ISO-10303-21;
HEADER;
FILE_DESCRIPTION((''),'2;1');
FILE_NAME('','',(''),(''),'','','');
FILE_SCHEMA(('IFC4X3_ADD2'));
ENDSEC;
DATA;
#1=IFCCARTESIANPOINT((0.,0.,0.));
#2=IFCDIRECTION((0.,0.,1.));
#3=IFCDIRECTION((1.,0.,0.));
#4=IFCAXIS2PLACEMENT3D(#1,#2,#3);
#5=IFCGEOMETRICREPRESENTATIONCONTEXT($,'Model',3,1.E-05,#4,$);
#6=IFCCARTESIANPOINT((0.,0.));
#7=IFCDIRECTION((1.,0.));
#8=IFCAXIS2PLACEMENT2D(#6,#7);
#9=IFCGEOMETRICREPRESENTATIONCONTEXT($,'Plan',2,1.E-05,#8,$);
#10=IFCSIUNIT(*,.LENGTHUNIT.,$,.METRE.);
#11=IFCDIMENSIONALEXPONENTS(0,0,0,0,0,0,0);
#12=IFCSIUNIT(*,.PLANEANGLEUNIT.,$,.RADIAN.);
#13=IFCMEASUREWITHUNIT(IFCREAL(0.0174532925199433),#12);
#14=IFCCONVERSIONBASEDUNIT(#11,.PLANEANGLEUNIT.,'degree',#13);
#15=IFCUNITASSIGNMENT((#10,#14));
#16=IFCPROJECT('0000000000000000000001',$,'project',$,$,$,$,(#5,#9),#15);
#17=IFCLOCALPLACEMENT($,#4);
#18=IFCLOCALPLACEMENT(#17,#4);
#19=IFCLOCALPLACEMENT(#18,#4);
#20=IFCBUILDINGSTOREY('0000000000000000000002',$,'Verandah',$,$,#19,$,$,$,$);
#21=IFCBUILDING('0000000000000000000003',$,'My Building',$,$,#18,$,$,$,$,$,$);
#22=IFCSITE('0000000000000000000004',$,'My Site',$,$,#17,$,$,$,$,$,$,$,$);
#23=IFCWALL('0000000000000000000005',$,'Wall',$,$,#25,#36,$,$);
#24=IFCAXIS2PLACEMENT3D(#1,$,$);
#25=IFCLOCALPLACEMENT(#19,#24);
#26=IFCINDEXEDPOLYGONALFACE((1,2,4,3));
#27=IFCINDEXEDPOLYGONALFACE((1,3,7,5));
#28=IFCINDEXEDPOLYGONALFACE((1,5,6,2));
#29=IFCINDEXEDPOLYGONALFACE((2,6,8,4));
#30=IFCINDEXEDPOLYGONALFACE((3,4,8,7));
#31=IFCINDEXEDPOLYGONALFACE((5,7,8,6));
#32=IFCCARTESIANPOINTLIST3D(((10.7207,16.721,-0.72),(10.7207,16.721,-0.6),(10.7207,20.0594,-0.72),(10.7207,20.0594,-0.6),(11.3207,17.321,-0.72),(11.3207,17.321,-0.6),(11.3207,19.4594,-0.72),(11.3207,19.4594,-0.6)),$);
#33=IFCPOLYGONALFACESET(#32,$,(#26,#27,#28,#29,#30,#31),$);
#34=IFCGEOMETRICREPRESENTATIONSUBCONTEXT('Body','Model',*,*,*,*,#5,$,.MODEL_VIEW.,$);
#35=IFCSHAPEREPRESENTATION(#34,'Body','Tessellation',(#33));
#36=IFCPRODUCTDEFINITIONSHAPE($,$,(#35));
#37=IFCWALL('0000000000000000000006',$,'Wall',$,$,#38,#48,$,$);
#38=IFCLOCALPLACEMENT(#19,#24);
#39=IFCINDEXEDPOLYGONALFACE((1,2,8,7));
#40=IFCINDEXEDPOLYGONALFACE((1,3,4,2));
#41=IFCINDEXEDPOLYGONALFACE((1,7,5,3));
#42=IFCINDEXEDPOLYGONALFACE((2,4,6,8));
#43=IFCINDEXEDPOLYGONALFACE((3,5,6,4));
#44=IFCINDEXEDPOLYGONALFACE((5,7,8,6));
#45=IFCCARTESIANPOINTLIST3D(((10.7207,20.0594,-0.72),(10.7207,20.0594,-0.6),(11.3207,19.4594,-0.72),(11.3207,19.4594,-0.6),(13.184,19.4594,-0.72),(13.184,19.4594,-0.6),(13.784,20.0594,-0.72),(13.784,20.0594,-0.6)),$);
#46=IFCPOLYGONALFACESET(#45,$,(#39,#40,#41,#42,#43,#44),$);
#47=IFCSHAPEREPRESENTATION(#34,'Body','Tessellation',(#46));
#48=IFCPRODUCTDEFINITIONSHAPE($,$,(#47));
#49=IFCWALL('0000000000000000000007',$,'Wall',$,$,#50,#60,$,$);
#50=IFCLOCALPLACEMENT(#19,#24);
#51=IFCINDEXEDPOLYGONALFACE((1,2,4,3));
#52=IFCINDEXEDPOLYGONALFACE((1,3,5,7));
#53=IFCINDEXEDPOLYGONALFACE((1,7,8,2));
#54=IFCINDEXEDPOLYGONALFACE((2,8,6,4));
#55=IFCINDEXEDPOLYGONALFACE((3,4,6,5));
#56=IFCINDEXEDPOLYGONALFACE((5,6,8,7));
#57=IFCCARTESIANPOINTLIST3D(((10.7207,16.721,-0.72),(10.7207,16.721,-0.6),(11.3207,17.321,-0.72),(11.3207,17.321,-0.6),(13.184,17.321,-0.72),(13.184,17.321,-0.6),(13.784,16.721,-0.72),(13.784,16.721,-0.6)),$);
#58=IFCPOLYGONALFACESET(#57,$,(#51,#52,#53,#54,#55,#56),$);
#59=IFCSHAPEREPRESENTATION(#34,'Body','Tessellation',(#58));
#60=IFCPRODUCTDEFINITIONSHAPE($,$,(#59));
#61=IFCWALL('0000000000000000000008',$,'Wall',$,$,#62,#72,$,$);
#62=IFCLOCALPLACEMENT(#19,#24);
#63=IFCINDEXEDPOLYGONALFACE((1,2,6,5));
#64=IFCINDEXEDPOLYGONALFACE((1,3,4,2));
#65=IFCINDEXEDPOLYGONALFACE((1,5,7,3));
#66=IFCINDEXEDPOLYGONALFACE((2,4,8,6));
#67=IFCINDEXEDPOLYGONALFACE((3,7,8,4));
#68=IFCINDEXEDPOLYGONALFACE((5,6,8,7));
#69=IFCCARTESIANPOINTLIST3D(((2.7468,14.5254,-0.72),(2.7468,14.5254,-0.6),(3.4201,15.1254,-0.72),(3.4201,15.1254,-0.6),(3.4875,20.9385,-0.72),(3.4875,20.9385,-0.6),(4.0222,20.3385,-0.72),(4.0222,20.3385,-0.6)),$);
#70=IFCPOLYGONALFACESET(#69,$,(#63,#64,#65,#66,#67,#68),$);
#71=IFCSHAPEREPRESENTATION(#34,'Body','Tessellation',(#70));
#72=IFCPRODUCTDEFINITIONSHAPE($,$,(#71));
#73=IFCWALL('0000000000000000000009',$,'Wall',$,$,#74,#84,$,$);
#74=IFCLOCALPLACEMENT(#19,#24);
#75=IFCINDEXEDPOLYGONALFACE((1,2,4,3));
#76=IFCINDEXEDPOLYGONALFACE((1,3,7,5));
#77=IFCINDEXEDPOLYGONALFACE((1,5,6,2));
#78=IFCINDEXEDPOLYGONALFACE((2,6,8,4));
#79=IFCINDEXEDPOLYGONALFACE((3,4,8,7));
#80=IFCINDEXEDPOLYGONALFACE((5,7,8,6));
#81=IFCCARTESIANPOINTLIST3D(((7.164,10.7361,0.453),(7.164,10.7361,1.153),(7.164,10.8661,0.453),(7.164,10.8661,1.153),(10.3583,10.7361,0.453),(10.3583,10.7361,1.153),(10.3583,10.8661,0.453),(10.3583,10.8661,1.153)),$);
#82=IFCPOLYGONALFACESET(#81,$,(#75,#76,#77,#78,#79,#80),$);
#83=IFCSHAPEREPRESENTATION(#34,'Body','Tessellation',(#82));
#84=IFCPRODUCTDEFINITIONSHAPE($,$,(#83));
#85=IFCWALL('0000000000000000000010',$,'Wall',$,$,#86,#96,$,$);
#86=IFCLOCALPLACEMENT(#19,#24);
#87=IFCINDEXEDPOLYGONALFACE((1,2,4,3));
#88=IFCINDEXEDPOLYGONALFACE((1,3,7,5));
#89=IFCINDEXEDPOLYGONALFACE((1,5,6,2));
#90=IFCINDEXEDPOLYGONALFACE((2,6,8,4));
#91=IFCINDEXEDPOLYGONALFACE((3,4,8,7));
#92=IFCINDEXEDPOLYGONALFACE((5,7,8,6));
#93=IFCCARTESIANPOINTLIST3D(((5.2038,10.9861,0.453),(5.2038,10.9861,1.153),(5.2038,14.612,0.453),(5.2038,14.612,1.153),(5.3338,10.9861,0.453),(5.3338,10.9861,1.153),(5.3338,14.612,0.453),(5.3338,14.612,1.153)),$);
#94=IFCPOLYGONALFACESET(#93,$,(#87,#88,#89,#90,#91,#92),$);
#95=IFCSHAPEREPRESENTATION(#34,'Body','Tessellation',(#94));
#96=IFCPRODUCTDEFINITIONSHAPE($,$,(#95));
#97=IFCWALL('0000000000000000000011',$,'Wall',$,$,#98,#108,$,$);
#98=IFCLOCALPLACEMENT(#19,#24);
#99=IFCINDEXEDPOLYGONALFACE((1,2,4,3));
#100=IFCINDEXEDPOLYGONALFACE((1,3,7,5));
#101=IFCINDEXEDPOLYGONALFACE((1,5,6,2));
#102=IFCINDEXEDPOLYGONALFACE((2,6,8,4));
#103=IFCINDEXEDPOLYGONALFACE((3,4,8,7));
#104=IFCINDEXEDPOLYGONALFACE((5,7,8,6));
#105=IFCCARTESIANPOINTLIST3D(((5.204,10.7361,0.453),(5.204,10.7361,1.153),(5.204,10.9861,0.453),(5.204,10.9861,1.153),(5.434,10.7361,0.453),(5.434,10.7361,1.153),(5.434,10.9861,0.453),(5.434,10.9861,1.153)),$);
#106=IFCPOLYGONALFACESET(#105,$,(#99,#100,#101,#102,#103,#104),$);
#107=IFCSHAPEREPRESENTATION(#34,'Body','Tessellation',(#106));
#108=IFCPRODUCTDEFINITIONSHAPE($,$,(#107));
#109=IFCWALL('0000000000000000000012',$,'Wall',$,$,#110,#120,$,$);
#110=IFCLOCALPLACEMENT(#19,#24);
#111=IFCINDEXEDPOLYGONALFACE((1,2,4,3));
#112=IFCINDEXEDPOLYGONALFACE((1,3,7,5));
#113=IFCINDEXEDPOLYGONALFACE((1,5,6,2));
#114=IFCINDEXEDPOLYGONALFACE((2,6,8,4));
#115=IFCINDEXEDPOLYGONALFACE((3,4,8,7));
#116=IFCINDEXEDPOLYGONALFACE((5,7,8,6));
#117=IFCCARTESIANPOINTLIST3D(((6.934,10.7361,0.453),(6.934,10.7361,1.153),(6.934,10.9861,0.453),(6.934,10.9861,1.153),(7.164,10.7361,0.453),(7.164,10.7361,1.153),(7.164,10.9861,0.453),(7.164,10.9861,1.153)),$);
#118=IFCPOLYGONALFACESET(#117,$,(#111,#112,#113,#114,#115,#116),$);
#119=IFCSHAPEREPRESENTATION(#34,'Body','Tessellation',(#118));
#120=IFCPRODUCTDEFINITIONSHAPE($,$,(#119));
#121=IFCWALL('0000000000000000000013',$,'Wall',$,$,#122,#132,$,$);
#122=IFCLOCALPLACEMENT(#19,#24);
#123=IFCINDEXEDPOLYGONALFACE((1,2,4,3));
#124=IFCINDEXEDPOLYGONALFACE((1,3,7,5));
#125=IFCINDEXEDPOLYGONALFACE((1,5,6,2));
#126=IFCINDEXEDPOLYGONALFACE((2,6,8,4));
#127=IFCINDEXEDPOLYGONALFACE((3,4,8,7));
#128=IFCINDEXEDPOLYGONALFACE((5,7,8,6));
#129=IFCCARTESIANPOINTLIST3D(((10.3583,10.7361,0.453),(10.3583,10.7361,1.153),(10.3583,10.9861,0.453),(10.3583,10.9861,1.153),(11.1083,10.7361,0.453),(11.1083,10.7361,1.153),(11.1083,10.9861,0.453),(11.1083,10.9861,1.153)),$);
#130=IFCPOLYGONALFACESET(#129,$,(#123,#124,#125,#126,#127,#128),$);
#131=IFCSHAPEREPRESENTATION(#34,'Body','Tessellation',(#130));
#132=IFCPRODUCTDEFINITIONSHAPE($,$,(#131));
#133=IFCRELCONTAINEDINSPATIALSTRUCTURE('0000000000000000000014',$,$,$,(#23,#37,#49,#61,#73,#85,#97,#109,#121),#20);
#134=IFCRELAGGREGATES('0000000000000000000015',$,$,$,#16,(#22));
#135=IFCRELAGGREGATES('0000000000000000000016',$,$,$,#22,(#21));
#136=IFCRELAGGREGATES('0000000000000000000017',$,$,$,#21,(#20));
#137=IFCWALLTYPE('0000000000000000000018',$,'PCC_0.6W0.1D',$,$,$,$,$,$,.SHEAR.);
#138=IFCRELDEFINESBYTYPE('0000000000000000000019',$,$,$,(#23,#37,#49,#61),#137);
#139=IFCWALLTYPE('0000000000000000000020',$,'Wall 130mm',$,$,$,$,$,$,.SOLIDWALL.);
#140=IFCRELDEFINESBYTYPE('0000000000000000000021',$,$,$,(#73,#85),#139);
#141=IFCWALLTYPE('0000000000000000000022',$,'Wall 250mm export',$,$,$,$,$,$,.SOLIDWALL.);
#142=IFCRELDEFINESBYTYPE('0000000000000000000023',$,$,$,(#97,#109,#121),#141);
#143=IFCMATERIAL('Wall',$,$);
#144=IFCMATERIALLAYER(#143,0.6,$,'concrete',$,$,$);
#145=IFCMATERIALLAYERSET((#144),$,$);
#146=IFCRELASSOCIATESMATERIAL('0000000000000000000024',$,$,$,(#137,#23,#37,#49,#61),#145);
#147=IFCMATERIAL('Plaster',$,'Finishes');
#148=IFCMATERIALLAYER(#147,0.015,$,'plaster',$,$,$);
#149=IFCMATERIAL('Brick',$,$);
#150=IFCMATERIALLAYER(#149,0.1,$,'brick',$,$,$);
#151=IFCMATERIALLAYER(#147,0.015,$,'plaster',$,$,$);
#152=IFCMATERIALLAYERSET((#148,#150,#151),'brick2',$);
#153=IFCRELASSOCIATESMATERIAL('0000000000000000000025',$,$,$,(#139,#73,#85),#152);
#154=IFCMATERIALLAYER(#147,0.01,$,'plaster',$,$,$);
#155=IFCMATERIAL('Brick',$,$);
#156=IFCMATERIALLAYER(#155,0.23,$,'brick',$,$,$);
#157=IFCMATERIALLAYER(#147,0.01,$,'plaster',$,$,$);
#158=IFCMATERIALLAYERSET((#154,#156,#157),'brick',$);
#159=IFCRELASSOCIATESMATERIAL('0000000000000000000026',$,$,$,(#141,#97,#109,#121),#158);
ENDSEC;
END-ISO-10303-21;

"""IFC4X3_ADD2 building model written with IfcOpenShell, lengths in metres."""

from ifc_helpers import new_model, entity, si_unit, converted_unit, frame, origin_with_axes, origin_2d_with_axis, place, context, subcontext, project, spatial, line, indexed_curve, outline, extrude, material, layer, layer_set, layer_usage, type_object, element, save


model = new_model("IFC4X3_ADD2")

# Units and contexts
model_context = context("Model", 3, precision=1e-05, world=origin_with_axes())
plan_context = context("Plan", 2, precision=1e-05, world=origin_2d_with_axis())
body_context = subcontext(model_context, "Body", "Model", "MODEL_VIEW")
ifc_project = project(units=[si_unit("LENGTHUNIT", "METRE"), converted_unit("PLANEANGLEUNIT", "degree", entity("IfcReal", 0.0174532925199433), si_unit("PLANEANGLEUNIT", "RADIAN"), dimensions=[0, 0, 0, 0, 0, 0, 0])], contexts=[model_context, plan_context])

# Site, building, storey
site_placement = place(None, origin_with_axes())
site = spatial("IfcSite", under=ifc_project, at=site_placement, Name="My Site")
building_placement = place(site_placement, origin_with_axes())
building = spatial("IfcBuilding", under=site, at=building_placement, Name="My Building")
storey_placement = place(building_placement, origin_with_axes())
storey = spatial("IfcBuildingStorey", under=building, at=storey_placement, Name="Verandah")

# Walls
ifc_material_1 = material(Name="Wall")
ifc_layer_1 = layer(ifc_material_1, 0.6, Name="concrete")
ifc_layer_set_1 = layer_set([ifc_layer_1])
wall_type_1 = type_object("IfcWallType", Name="PCC_0.6W0.1D", PredefinedType="SHEAR", material=ifc_layer_set_1)
ifc_layer_usage_1 = layer_usage(ifc_layer_set_1, "AXIS2", "POSITIVE", 0.0)
wall_1_placement = place(storey_placement, frame((10.7207, 19.4594, -0.72), z_axis=(0.0, 0.0, 1.0), x_axis=(-0.000001, -1.0, 0.0)))
element("IfcWall", 1, at=wall_1_placement, inside=storey, type_object=wall_type_1, material=ifc_layer_usage_1, Name="Wall", context=body_context, shape_type="SweptSolid", body=[
    extrude(outline(indexed_curve([(-0.6, 0.0), (0.0, 0.6), (2.1384, 0.6), (2.7384, 0.0)], segments=[line(1, 2, 3, 4, 1)])), origin_with_axes(), (0.0, 0.0, 1.0), 0.12),
])
ifc_layer_usage_2 = layer_usage(ifc_layer_set_1, "AXIS2", "POSITIVE", 0.0)
wall_2_placement = place(storey_placement, frame((10.7207, 19.4594, -0.72), z_axis=(0.0, 0.0, 1.0), x_axis=(1.0, -0.000001, 0.0)))
element("IfcWall", 2, at=wall_2_placement, inside=storey, type_object=wall_type_1, material=ifc_layer_usage_2, Name="Wall", context=body_context, shape_type="SweptSolid", body=[
    extrude(outline(indexed_curve([(0.6, 0.0), (0.0, 0.6), (3.0633, 0.6), (2.4633, 0.0)], segments=[line(1, 2, 3, 4, 1)])), origin_with_axes(), (0.0, 0.0, 1.0), 0.12),
])
ifc_layer_usage_3 = layer_usage(ifc_layer_set_1, "AXIS2", "POSITIVE", 0.0)
wall_3_placement = place(storey_placement, frame((10.7207, 16.721, -0.72), z_axis=(0.0, 0.0, 1.0), x_axis=(1.0, -0.000001, 0.0)))
element("IfcWall", 3, at=wall_3_placement, inside=storey, type_object=wall_type_1, material=ifc_layer_usage_3, Name="Wall", context=body_context, shape_type="SweptSolid", body=[
    extrude(outline(indexed_curve([(0.0, 0.0), (0.6, 0.6), (2.4633, 0.6), (3.0633, 0.0)], segments=[line(1, 2, 3, 4, 1)])), origin_with_axes(), (0.0, 0.0, 1.0), 0.12),
])
ifc_layer_usage_4 = layer_usage(ifc_layer_set_1, "AXIS2", "POSITIVE", 0.0)
wall_4_placement = place(storey_placement, frame((3.4875, 20.9385, -0.72), z_axis=(0.0, 0.0, 1.0), x_axis=(-0.114729, -0.993397, 0.0)))
element("IfcWall", 4, at=wall_4_placement, inside=storey, type_object=wall_type_1, material=ifc_layer_usage_4, Name="Wall", context=body_context, shape_type="SweptSolid", body=[
    extrude(outline(indexed_curve([(0.0, 0.0), (0.5347, 0.6), (5.7825, 0.6), (6.4557, 0.0)], segments=[line(1, 2, 3, 4, 1)])), origin_with_axes(), (0.0, 0.0, 1.0), 0.12),
])
ifc_material_2 = material(Name="Plaster", Category="Finishes")
ifc_layer_2 = layer(ifc_material_2, 0.015, Name="plaster")
ifc_material_3 = material(Name="Brick")
ifc_layer_3 = layer(ifc_material_3, 0.1, Name="brick")
ifc_layer_4 = layer(ifc_material_2, 0.015, Name="plaster")
ifc_layer_set_2 = layer_set([ifc_layer_2, ifc_layer_3, ifc_layer_4], Name="brick2")
ifc_layer_usage_5 = layer_usage(ifc_layer_set_2, "AXIS2", "POSITIVE", 0.0)
wall_type_2 = type_object("IfcWallType", Name="Wall 130mm", PredefinedType="SOLIDWALL", material=ifc_layer_set_2)
wall_5_placement = place(storey_placement, frame((7.164, 10.7361, 0.453), z_axis=(0.0, 0.0, 1.0), x_axis=(1.0, 0.0, 0.0)))
element("IfcWall", 5, at=wall_5_placement, inside=storey, type_object=wall_type_2, material=ifc_layer_usage_5, Name="Wall", context=body_context, shape_type="SweptSolid", body=[
    extrude(outline(indexed_curve([(0.0, 0.0), (0.0, 0.13), (3.1943, 0.13), (3.1943, 0.0)], segments=[line(1, 2, 3, 4, 1)])), origin_with_axes(), (0.0, 0.0, 1.0), 0.7),
])
ifc_layer_usage_6 = layer_usage(ifc_layer_set_2, "AXIS2", "POSITIVE", 0.0)
wall_6_placement = place(storey_placement, frame((5.2038, 14.612, 0.453), z_axis=(0.0, 0.0, 1.0), x_axis=(0.0, -1.0, 0.0)))
element("IfcWall", 6, at=wall_6_placement, inside=storey, type_object=wall_type_2, material=ifc_layer_usage_6, Name="Wall", context=body_context, shape_type="SweptSolid", body=[
    extrude(outline(indexed_curve([(0.0, 0.0), (0.0, 0.13), (3.6259, 0.13), (3.6259, 0.0)], segments=[line(1, 2, 3, 4, 1)])), origin_with_axes(), (0.0, 0.0, 1.0), 0.7),
])
ifc_layer_5 = layer(ifc_material_2, 0.01, Name="plaster")
ifc_material_4 = material(Name="Brick")
ifc_layer_6 = layer(ifc_material_4, 0.23, Name="brick")
ifc_layer_7 = layer(ifc_material_2, 0.01, Name="plaster")
ifc_layer_set_3 = layer_set([ifc_layer_5, ifc_layer_6, ifc_layer_7], Name="brick")
ifc_layer_usage_7 = layer_usage(ifc_layer_set_3, "AXIS2", "POSITIVE", 0.0)
wall_type_3 = type_object("IfcWallType", Name="Wall 250mm export", PredefinedType="SOLIDWALL", material=ifc_layer_set_3)
wall_7_placement = place(storey_placement, frame((5.204, 10.7361, 0.453), z_axis=(0.0, 0.0, 1.0), x_axis=(1.0, -0.000001, 0.0)))
element("IfcWall", 7, at=wall_7_placement, inside=storey, type_object=wall_type_3, material=ifc_layer_usage_7, Name="Wall", context=body_context, shape_type="SweptSolid", body=[
    extrude(outline(indexed_curve([(0.0, 0.0), (0.0, 0.25), (0.23, 0.25), (0.23, 0.0)], segments=[line(1, 2, 3, 4, 1)])), origin_with_axes(), (0.0, 0.0, 1.0), 0.7),
])
ifc_layer_usage_8 = layer_usage(ifc_layer_set_3, "AXIS2", "POSITIVE", 0.0)
wall_8_placement = place(storey_placement, frame((6.934, 10.7361, 0.453), z_axis=(0.0, 0.0, 1.0), x_axis=(1.0, -0.000001, 0.0)))
element("IfcWall", 8, at=wall_8_placement, inside=storey, type_object=wall_type_3, material=ifc_layer_usage_8, Name="Wall", context=body_context, shape_type="SweptSolid", body=[
    extrude(outline(indexed_curve([(0.0, 0.0), (0.0, 0.25), (0.23, 0.25), (0.23, 0.0)], segments=[line(1, 2, 3, 4, 1)])), origin_with_axes(), (0.0, 0.0, 1.0), 0.7),
])
ifc_layer_usage_9 = layer_usage(ifc_layer_set_3, "AXIS2", "POSITIVE", 0.0)
wall_9_placement = place(storey_placement, frame((10.3583, 10.7361, 0.453), z_axis=(0.0, 0.0, 1.0), x_axis=(1.0, -0.000001, 0.0)))
element("IfcWall", 9, at=wall_9_placement, inside=storey, type_object=wall_type_3, material=ifc_layer_usage_9, Name="Wall", context=body_context, shape_type="SweptSolid", body=[
    extrude(outline(indexed_curve([(0.0, 0.0), (0.0, 0.25), (0.75, 0.25), (0.75, 0.0)], segments=[line(1, 2, 3, 4, 1)])), origin_with_axes(), (0.0, 0.0, 1.0), 0.7),
])

save(model, "model.ifc")
